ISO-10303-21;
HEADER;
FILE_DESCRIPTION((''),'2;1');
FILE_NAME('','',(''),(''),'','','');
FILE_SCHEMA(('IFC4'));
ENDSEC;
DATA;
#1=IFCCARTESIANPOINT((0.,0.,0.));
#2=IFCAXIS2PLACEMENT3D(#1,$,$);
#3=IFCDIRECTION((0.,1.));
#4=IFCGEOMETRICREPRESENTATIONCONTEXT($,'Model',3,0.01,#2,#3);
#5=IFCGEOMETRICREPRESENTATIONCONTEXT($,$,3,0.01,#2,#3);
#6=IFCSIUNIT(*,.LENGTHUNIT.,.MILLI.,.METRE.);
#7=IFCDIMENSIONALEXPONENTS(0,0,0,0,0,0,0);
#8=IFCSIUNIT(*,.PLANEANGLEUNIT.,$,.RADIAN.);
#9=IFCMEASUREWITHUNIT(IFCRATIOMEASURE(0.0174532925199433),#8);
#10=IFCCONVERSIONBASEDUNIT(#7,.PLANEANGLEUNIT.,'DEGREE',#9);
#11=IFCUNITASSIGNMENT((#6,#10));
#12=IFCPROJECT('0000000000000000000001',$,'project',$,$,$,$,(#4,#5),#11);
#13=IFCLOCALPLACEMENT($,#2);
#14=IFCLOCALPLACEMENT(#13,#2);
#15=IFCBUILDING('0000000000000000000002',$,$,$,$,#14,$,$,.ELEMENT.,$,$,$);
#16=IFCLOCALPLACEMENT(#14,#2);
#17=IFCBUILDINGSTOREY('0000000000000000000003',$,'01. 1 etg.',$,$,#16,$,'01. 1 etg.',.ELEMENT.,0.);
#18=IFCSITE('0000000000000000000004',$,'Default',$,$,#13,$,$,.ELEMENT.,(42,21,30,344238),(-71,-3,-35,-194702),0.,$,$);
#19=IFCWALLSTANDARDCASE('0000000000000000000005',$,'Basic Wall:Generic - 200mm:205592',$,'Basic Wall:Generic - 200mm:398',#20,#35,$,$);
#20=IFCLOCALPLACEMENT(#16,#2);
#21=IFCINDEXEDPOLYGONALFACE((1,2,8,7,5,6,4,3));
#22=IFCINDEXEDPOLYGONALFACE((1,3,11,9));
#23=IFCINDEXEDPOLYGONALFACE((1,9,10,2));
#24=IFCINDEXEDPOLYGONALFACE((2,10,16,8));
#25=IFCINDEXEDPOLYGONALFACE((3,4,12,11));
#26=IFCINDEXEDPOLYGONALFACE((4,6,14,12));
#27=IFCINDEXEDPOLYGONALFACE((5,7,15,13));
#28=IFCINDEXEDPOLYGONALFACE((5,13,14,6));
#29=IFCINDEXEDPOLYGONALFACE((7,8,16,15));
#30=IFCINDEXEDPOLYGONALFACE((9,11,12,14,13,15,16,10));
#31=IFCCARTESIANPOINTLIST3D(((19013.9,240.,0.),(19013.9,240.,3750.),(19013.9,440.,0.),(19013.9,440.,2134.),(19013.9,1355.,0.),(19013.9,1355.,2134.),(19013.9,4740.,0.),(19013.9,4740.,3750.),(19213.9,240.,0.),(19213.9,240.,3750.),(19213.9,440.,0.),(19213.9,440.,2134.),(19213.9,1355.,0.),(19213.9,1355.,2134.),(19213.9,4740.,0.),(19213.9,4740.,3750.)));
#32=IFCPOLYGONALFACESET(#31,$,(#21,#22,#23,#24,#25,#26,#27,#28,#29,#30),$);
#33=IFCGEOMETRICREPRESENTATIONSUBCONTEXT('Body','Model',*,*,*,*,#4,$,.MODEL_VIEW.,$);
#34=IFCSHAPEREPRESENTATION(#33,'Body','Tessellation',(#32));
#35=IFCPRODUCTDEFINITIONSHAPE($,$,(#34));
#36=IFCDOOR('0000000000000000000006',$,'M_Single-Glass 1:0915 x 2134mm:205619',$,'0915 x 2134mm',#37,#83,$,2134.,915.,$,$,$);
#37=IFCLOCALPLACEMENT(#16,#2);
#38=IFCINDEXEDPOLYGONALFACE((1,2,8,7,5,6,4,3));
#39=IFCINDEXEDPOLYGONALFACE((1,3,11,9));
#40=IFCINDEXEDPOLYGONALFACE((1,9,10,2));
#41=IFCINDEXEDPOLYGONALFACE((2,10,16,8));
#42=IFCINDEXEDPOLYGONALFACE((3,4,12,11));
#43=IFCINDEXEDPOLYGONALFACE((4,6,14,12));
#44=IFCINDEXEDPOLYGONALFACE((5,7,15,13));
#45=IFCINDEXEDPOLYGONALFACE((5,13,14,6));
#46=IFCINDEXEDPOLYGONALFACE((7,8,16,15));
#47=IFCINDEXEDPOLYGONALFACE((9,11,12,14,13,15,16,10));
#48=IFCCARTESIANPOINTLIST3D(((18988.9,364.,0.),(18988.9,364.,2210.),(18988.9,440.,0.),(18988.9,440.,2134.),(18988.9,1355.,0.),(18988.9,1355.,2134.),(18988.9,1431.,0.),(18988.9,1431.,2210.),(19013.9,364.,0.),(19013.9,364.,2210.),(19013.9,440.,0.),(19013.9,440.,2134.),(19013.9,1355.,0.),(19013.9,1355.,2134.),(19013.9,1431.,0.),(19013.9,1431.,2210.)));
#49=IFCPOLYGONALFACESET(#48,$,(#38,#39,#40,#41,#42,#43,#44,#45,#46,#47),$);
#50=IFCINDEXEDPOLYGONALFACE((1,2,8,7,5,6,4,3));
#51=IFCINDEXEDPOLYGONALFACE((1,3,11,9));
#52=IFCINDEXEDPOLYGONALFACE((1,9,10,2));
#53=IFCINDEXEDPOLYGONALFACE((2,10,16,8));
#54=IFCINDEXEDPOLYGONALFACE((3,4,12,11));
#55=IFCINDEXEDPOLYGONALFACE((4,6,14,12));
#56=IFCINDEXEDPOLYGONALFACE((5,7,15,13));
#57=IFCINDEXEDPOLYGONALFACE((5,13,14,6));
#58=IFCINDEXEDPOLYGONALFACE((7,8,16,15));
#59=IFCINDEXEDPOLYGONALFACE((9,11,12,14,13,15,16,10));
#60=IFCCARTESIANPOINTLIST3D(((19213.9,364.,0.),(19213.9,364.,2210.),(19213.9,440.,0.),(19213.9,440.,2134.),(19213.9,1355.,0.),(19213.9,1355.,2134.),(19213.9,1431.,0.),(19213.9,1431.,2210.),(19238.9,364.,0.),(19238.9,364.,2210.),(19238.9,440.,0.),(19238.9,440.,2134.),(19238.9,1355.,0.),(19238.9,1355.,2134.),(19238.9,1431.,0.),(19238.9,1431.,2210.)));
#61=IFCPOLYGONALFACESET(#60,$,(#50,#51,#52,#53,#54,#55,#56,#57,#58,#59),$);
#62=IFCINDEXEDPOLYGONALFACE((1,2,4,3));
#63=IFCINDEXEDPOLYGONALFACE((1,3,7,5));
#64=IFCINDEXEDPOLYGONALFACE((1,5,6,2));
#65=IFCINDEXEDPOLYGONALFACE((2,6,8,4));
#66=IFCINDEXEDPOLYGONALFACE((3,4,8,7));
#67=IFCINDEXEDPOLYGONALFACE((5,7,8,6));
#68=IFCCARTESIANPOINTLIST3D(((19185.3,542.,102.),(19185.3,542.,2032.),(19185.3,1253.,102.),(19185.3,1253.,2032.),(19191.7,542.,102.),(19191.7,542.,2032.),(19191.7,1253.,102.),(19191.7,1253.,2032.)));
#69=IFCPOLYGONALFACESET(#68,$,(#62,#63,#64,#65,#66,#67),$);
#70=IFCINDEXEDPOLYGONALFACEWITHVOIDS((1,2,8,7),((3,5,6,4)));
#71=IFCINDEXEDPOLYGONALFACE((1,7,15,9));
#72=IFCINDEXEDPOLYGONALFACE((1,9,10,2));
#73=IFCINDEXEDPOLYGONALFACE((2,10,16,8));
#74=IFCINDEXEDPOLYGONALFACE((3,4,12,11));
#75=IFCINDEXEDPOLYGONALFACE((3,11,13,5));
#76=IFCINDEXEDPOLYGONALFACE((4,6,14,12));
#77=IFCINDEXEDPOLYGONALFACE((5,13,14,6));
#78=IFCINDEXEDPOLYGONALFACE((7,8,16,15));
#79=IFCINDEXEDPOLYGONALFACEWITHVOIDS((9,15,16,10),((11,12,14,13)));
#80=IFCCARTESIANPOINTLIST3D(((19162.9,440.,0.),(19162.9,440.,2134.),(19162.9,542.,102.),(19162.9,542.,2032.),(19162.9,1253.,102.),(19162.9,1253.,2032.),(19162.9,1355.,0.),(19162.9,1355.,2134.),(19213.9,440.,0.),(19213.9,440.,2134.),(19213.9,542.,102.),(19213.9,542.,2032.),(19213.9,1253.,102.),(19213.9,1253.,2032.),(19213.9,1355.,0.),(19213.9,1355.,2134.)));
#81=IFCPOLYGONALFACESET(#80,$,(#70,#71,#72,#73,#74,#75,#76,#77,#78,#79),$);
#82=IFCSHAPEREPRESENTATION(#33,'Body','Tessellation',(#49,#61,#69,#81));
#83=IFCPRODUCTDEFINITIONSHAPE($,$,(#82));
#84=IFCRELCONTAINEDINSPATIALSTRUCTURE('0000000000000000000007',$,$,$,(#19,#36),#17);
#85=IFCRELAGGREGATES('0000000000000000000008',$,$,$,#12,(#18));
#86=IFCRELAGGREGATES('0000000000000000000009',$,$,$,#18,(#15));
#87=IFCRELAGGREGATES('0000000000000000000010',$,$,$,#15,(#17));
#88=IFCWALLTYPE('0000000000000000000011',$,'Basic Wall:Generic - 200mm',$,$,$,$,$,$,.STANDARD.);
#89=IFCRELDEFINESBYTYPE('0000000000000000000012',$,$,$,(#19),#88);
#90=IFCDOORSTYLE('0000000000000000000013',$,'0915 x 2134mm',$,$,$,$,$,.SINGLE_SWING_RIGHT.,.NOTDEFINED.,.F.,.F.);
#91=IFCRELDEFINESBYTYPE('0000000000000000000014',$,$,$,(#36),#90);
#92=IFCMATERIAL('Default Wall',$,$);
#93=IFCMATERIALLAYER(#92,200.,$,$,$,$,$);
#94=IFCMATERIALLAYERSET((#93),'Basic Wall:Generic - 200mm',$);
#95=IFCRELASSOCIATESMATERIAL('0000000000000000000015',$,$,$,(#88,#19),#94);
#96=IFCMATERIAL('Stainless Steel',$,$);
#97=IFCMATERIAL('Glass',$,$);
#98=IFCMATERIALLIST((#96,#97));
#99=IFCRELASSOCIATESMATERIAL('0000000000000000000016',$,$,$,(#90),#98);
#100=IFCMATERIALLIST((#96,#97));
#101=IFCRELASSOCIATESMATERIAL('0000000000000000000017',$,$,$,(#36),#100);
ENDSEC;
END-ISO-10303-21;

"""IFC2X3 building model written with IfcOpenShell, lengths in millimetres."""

from ifc_helpers import new_model, entity, si_unit, converted_unit, direction, frame, frame_2d, origin, place, context, subcontext, project, spatial, polyline, rectangle, outline, extrude, source, transform, mapped, material, material_list, layer, layer_set, layer_usage, type_object, type_shapes, element, fill, save


model = new_model("IFC2X3")

# Units and contexts
model_context = context("Model", 3, precision=0.01, world=origin(), true_north=direction((0.0, 1.0)))
context_of_model = context(None, 3, precision=0.01, world=origin(), true_north=direction((0.0, 1.0)))
body_context = subcontext(model_context, "Body", "Model", "MODEL_VIEW")
ifc_project = project(units=[si_unit("LENGTHUNIT", "METRE", prefix="MILLI"), converted_unit("PLANEANGLEUNIT", "DEGREE", entity("IfcRatioMeasure", 0.0174532925199433), si_unit("PLANEANGLEUNIT", "RADIAN"), dimensions=[0, 0, 0, 0, 0, 0, 0])], contexts=[model_context, context_of_model])

# Site, building, storey
site_placement = place(None, origin())
site = spatial("IfcSite", under=ifc_project, at=site_placement, Name="Default", CompositionType="ELEMENT", RefLatitude=(42, 21, 30, 344238), RefLongitude=(-71, -3, -35, -194702), RefElevation=0.0)
building_placement = place(site_placement, origin())
building = spatial("IfcBuilding", under=site, at=building_placement, CompositionType="ELEMENT")
storey_placement = place(building_placement, origin())
storey = spatial("IfcBuildingStorey", under=building, at=storey_placement, Name="01. 1 etg.", LongName="01. 1 etg.", CompositionType="ELEMENT", Elevation=0.0)

# Shared definitions
ifc_material_1 = material(Name="Glass")
ifc_material_2 = material(Name="Stainless Steel")

# Wall, opening, door
ifc_material_3 = material(Name="Default Wall")
ifc_layer_1 = layer(ifc_material_3, 200.0)
ifc_layer_set_1 = layer_set([ifc_layer_1], Name="Basic Wall:Generic - 200mm")
ifc_layer_usage_1 = layer_usage(ifc_layer_set_1, "AXIS2", "NEGATIVE", 100.0)
wall_type_1 = type_object("IfcWallType", Name="Basic Wall:Generic - 200mm", PredefinedType="STANDARD", material=ifc_layer_set_1)
wall_1_placement = place(storey_placement, frame((19113.9, 4740.0, 0.0), z_axis=(0.0, 0.0, 1.0), x_axis=(0.0, -1.0, 0.0)))
wall_1 = element("IfcWallStandardCase", 1, at=wall_1_placement, inside=storey, type_object=wall_type_1, material=ifc_layer_usage_1, Name="Basic Wall:Generic - 200mm:205592", ObjectType="Basic Wall:Generic - 200mm:398", context=body_context, shape_type="SweptSolid", body=[
    extrude(rectangle(XDim=4500.0, YDim=200.0, at=frame_2d((2250.0, 0.0), x_axis=(-1.0, 0.0))), origin(), (0.0, 0.0, 1.0), 3750.0),
])
opening_1_placement = place(wall_1_placement, frame((3385.0, -100.0, 0.0)))
opening_1 = element("IfcOpeningElement", 2, at=opening_1_placement, cuts=wall_1, ObjectType="Opening", context=body_context, shape_type="SweptSolid", body=[
    extrude(rectangle(XDim=915.0, YDim=2134.0, at=frame_2d((1067.0, 457.5), x_axis=(0.0, 1.0))), frame((0.0, 0.0, 0.0), z_axis=(0.0, 1.0, 0.0), x_axis=(0.0, 0.0, 1.0)), (0.0, 0.0, 1.0), 200.0),
])
ifc_material_list_1 = material_list([ifc_material_2, ifc_material_1])
ifc_material_list_2 = material_list([ifc_material_2, ifc_material_1])
door_style_1 = type_object("IfcDoorStyle", Name="0915 x 2134mm", ConstructionType="NOTDEFINED", OperationType="SINGLE_SWING_RIGHT", ParameterTakesPrecedence=False, Sizeable=False, material=ifc_material_list_2)
shared_shape_1 = source(origin(), body_context, "Body", "SweptSolid", [
    extrude(outline(polyline([(-457.5, -1048.0), (-457.5, 1086.0), (-533.5, 1086.0), (-533.5, -1124.0), (533.5, -1124.0), (533.5, 1086.0), (457.5, 1086.0), (457.5, -1048.0), (-457.5, -1048.0)])), frame((457.5, -25.0, 1086.0), z_axis=(0.0, -1.0, 0.0), x_axis=(-1.0, 0.0, 0.0)), (0.0, 0.0, -1.0), 25.0),
    extrude(outline(polyline([(-457.5, -1048.0), (-457.5, 1086.0), (-533.5, 1086.0), (-533.5, -1124.0), (533.5, -1124.0), (533.5, 1086.0), (457.5, 1086.0), (457.5, -1048.0), (-457.5, -1048.0)])), frame((457.5, 200.0, 1086.0), z_axis=(0.0, -1.0, 0.0), x_axis=(-1.0, 0.0, 0.0)), (0.0, 0.0, -1.0), 25.0),
    extrude(rectangle(XDim=6.3, YDim=711.0, at=frame_2d((0.0, 0.0), x_axis=(1.0, 0.0))), frame((457.5, 174.6, 102.0), z_axis=(0.0, 0.0, 1.0), x_axis=(0.0, 1.0, 0.0)), (0.0, 0.0, 1.0), 1930.0),
    extrude(outline(polyline([(-1067.0, -457.5), (1067.0, -457.5), (1067.0, 457.5), (-1067.0, 457.5), (-1067.0, -457.5)]), holes=[polyline([(-965.0, 355.5), (965.0, 355.5), (965.0, -355.5), (-965.0, -355.5), (-965.0, 355.5)])]), frame((457.5, 149.0, 1067.0), z_axis=(0.0, 1.0, 0.0), x_axis=(0.0, 0.0, -1.0)), (0.0, 0.0, 1.0), 51.0),
])
type_shapes(door_style_1, [shared_shape_1])
door_1_placement = place(opening_1_placement, origin())
door_1 = element("IfcDoor", 3, at=door_1_placement, inside=storey, type_object=door_style_1, material=ifc_material_list_1, Name="M_Single-Glass 1:0915 x 2134mm:205619", ObjectType="0915 x 2134mm", OverallHeight=2134.0, OverallWidth=915.0, context=body_context, shape_type="MappedRepresentation", body=[
    mapped(shared_shape_1, transform((0.0, 0.0, 0.0), scale=1.0)),
])
fill(opening_1, door_1)

save(model, "model.ifc")
